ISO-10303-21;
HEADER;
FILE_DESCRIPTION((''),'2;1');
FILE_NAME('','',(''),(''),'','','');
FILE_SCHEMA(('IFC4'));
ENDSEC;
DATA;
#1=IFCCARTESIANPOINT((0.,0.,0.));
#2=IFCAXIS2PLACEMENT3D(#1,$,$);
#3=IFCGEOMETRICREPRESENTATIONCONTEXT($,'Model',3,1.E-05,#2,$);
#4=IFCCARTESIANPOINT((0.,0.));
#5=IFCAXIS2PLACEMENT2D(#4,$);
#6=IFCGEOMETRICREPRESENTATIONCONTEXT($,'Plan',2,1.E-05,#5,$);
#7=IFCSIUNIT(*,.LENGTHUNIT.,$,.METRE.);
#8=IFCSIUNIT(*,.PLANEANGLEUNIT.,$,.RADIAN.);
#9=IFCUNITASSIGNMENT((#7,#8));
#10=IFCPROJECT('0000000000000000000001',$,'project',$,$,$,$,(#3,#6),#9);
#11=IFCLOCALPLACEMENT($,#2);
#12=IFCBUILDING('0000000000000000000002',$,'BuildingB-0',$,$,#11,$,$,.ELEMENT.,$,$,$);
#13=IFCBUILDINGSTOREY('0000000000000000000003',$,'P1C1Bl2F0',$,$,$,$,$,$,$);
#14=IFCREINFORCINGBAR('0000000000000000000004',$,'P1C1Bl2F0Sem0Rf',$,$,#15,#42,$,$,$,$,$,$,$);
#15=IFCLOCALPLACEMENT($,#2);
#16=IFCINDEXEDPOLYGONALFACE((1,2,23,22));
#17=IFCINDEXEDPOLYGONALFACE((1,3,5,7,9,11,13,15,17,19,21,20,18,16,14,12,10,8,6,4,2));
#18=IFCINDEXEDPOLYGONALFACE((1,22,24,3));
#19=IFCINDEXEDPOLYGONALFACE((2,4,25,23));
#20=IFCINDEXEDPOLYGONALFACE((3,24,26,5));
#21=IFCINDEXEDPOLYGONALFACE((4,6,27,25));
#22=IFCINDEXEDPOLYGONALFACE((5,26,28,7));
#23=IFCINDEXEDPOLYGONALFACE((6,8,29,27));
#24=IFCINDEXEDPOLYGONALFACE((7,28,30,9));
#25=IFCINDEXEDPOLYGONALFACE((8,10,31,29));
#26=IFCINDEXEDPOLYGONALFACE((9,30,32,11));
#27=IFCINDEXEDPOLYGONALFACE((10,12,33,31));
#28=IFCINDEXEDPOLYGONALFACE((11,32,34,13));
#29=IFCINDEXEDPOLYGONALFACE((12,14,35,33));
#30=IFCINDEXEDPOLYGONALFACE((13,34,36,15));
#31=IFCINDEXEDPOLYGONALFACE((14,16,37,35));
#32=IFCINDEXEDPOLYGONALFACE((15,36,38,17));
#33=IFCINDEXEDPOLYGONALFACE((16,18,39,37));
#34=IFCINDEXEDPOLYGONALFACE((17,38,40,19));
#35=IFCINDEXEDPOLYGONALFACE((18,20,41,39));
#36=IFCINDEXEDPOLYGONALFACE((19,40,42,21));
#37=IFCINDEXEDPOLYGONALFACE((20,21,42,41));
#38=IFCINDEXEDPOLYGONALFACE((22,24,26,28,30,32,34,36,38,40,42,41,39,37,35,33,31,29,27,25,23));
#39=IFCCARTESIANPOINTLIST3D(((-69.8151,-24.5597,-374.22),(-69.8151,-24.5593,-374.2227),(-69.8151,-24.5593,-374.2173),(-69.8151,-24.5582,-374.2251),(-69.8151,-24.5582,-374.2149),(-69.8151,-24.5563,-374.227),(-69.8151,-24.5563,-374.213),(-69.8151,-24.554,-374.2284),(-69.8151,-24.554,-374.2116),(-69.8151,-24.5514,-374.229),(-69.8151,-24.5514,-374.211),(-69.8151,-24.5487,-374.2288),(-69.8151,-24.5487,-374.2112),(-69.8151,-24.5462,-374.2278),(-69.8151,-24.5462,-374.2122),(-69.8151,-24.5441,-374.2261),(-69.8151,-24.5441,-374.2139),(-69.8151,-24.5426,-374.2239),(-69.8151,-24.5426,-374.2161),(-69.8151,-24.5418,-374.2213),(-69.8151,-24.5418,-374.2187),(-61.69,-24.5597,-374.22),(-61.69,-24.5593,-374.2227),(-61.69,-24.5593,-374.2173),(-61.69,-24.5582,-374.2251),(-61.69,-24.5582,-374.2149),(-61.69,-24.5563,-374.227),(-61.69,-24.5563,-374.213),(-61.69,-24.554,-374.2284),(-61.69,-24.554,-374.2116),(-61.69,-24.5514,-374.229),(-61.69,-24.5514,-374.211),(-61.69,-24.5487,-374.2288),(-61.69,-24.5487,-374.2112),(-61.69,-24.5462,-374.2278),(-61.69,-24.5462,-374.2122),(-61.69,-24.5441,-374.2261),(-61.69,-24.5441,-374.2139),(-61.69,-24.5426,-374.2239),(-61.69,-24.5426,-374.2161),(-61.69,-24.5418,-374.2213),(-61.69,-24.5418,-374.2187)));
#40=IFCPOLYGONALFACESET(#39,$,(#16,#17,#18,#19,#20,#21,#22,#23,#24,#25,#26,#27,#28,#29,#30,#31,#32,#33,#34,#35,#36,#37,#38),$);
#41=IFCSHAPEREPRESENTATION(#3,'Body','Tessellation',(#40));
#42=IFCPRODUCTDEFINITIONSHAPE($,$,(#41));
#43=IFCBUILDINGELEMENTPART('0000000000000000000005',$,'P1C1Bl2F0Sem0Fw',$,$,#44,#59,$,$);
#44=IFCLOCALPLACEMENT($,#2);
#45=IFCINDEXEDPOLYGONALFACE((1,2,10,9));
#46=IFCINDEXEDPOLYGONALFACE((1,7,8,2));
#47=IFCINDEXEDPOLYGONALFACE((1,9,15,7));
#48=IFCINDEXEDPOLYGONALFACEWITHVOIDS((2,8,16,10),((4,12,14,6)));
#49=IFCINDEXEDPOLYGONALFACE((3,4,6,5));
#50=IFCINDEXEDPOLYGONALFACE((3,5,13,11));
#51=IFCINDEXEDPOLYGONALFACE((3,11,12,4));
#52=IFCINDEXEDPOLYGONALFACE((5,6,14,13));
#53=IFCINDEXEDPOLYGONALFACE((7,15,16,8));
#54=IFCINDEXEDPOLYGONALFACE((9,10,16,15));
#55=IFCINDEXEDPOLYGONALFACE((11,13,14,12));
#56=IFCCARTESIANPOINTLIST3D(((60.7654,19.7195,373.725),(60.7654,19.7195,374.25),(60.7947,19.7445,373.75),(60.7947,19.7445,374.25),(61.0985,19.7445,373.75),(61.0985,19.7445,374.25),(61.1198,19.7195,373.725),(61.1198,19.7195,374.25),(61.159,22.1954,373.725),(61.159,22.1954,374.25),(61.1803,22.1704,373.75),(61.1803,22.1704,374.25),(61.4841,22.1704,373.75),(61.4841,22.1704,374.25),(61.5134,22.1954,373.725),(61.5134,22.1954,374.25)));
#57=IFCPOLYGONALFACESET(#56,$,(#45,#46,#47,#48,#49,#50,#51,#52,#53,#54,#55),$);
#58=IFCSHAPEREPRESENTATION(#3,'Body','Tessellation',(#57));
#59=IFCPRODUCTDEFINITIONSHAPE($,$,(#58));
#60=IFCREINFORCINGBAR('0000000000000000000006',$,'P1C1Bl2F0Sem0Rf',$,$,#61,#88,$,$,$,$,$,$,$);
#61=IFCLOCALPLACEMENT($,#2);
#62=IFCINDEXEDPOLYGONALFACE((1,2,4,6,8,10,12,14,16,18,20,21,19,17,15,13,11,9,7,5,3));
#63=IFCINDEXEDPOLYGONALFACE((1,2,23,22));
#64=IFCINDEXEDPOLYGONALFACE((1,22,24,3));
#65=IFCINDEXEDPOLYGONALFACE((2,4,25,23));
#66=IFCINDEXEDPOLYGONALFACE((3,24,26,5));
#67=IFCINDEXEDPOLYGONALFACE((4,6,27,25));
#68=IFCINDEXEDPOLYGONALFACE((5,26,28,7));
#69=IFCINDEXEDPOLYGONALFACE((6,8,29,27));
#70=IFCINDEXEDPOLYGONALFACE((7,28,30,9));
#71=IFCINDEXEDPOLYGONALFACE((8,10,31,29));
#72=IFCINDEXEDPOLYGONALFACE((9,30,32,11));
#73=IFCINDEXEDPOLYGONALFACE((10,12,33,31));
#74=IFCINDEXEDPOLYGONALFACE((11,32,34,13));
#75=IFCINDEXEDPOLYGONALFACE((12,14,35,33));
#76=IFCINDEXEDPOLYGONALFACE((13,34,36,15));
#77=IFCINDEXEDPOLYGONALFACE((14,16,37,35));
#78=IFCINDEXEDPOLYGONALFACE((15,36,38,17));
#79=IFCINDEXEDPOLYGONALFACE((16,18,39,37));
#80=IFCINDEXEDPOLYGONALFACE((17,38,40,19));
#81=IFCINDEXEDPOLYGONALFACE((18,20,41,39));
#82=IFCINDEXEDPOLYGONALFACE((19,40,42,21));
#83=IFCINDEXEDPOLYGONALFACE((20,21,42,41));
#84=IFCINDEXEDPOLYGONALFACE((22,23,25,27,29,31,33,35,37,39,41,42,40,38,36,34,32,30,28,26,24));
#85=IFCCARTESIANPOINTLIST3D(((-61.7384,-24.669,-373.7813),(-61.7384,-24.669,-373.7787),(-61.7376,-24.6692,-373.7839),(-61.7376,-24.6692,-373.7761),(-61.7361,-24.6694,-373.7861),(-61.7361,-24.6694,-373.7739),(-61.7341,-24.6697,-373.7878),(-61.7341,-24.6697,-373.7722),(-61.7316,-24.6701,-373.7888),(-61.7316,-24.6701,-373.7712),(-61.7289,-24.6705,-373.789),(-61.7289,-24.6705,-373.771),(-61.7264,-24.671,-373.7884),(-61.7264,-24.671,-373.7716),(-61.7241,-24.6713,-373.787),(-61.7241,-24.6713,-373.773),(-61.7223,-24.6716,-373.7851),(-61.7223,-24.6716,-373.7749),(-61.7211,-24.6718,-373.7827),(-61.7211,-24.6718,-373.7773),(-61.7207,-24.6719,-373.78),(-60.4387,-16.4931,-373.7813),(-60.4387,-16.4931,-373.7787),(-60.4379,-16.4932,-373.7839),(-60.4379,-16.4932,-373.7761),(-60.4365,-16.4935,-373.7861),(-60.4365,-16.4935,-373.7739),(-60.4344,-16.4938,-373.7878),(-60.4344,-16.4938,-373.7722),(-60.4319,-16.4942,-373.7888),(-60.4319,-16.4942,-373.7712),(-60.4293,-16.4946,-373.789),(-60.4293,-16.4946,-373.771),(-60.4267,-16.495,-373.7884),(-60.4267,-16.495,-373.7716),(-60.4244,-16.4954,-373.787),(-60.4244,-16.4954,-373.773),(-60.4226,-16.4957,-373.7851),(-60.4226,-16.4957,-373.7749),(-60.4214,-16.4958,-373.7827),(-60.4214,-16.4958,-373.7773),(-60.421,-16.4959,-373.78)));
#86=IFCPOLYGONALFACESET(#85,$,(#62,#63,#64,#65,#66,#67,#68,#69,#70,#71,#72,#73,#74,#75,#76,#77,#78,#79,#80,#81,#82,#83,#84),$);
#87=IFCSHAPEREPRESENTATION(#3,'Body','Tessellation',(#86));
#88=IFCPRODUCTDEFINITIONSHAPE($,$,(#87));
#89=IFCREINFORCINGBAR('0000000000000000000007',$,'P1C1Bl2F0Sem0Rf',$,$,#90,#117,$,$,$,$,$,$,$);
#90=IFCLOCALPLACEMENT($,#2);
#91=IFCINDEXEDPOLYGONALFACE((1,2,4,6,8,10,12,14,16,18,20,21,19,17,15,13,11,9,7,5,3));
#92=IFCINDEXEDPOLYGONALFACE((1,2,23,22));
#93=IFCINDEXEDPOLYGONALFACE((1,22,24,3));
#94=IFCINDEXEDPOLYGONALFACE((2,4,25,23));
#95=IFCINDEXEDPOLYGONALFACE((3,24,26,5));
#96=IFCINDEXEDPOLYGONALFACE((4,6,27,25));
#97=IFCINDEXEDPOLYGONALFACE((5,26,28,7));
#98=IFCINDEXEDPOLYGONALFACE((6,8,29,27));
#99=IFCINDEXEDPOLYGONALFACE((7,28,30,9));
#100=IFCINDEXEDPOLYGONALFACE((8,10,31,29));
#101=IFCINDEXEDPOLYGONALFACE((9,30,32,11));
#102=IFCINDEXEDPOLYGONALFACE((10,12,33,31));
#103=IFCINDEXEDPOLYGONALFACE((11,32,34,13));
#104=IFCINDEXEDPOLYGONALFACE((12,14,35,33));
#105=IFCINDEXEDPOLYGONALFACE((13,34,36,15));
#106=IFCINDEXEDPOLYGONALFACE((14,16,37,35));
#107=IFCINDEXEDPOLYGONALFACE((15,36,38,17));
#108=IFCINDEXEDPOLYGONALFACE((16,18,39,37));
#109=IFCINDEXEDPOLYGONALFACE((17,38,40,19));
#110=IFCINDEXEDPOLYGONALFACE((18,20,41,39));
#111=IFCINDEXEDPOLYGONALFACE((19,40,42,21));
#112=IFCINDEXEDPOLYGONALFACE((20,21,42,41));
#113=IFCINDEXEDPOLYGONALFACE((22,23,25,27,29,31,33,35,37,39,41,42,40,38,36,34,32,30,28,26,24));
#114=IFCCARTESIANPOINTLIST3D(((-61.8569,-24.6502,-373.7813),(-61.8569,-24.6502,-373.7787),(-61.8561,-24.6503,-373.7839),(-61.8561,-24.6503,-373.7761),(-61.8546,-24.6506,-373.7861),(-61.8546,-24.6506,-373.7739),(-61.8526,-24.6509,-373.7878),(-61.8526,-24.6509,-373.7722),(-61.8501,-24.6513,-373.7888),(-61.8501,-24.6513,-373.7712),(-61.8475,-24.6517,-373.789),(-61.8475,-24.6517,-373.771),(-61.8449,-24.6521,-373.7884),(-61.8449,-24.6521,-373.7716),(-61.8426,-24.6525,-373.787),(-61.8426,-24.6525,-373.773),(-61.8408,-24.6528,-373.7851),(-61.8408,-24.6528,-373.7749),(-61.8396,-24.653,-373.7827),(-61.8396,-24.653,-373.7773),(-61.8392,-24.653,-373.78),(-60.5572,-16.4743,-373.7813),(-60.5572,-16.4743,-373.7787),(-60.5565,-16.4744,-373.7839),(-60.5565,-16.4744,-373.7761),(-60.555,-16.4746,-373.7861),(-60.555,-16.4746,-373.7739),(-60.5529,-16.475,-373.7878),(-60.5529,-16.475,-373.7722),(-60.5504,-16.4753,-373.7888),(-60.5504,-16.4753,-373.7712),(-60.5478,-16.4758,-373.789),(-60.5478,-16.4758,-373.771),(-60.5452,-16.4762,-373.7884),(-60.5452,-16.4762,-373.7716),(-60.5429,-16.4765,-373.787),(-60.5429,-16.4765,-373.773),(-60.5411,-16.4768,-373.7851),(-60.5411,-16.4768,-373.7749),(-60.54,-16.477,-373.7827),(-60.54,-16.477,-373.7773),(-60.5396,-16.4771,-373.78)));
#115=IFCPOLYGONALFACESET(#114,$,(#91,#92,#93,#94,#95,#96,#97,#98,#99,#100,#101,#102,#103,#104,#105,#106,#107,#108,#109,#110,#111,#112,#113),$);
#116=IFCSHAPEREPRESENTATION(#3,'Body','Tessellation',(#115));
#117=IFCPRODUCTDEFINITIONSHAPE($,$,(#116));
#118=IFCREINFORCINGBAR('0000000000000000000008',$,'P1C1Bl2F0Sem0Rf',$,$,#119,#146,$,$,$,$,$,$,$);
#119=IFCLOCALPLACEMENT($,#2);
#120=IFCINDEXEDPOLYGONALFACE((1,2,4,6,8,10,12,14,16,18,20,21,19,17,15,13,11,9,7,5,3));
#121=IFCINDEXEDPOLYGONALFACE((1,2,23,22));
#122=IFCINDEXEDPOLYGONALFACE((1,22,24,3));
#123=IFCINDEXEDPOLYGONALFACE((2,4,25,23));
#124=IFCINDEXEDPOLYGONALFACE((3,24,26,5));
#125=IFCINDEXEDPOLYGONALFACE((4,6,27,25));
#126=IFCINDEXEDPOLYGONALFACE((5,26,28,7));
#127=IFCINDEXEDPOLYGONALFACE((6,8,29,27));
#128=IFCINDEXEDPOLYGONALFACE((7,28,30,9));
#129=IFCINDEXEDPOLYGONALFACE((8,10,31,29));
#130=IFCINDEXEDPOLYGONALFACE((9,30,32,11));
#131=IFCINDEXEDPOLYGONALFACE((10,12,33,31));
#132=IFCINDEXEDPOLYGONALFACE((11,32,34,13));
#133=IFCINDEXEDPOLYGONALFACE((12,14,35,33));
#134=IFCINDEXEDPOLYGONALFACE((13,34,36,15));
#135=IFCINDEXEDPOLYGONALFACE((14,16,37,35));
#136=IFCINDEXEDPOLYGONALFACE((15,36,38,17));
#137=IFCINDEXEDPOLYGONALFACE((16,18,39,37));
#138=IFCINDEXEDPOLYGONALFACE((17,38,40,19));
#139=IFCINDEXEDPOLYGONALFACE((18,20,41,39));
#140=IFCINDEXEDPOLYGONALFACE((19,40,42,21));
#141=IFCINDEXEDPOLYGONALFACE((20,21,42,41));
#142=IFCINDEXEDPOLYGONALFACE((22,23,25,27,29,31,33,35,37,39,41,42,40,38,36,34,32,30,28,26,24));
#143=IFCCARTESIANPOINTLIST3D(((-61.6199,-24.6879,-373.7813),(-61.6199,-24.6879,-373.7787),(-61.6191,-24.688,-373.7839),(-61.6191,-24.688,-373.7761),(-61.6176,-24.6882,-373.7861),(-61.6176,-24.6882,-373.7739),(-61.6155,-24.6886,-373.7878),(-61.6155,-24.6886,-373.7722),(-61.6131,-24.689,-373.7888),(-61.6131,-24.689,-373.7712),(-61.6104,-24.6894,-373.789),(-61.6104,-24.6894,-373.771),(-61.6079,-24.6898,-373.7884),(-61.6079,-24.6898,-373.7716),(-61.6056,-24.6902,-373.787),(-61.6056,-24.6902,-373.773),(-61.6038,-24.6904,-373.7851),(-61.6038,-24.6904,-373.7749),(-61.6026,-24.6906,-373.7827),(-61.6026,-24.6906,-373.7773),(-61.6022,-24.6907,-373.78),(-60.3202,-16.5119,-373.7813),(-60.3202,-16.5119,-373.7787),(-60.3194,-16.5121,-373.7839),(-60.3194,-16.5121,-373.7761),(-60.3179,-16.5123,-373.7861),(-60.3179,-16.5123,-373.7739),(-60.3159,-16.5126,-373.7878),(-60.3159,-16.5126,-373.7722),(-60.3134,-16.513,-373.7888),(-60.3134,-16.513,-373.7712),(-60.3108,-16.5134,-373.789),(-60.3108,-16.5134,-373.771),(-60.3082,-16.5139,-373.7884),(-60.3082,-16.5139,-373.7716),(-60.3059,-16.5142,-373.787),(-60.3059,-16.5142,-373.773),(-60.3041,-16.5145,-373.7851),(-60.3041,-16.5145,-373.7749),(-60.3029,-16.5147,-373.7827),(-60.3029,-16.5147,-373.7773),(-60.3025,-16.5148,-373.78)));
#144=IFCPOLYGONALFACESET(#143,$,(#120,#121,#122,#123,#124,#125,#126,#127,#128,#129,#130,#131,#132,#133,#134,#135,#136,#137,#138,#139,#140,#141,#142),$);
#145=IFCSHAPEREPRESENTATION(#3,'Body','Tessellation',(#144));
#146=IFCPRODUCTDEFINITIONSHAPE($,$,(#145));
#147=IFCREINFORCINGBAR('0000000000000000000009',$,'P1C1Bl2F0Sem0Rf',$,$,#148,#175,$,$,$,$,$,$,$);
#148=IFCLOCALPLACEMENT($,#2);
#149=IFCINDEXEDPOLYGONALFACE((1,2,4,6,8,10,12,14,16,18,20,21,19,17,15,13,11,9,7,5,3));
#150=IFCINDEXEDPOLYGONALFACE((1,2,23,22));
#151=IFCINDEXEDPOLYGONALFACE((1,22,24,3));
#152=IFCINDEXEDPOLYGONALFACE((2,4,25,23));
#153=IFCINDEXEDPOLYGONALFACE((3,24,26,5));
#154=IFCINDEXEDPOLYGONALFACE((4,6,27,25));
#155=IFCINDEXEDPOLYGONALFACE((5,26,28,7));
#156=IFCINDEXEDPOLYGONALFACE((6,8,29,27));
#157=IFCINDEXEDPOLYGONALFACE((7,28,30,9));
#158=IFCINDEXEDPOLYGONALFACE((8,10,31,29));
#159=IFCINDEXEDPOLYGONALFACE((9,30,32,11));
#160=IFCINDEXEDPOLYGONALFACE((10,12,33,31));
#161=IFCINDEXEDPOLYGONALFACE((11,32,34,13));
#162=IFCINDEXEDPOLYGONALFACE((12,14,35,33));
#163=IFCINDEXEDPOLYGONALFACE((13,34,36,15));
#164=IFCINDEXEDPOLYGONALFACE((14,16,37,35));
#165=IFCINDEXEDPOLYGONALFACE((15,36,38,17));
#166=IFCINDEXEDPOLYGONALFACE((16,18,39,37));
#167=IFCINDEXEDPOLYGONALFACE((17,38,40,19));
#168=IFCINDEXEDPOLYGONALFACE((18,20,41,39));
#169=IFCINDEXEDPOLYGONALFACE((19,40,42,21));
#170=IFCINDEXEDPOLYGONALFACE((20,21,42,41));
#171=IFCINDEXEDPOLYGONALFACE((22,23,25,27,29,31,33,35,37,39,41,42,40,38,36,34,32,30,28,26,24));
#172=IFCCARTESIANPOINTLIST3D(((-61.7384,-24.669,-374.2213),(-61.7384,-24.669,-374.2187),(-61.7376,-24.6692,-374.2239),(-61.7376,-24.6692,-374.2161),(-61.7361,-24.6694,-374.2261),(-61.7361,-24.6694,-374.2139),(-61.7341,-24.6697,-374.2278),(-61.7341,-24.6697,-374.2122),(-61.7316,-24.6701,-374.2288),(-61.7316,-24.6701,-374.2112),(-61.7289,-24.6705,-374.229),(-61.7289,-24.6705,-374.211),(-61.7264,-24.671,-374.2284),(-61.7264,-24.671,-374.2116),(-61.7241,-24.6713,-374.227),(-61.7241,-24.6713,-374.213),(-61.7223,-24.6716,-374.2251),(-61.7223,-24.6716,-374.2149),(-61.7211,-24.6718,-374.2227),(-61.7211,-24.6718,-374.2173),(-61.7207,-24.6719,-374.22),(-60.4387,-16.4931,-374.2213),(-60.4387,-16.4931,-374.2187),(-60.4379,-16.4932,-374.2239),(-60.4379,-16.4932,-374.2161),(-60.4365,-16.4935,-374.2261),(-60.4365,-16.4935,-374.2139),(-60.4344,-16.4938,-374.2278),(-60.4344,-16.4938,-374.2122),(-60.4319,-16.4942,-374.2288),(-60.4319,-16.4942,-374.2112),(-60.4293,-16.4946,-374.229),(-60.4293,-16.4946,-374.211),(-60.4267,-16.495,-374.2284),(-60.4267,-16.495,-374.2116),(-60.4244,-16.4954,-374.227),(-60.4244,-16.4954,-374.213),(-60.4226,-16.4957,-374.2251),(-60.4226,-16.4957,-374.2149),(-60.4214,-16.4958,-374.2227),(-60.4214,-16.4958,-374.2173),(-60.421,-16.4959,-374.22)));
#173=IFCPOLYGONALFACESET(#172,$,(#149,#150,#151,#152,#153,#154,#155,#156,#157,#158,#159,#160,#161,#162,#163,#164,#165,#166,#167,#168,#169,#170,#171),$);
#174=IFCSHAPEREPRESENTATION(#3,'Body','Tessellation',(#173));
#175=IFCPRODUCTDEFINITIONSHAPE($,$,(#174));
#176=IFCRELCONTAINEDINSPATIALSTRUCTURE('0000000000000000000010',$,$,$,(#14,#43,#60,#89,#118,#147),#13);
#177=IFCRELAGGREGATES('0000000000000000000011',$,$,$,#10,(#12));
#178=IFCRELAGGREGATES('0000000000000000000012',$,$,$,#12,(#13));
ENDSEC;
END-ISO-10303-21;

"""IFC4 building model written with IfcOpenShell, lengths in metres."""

from ifc_helpers import new_model, entity, si_unit, origin, origin_2d, place, context, project, spatial, polyline, outline, extrude, element, save


model = new_model("IFC4")

# Units and contexts
model_context = context("Model", 3, precision=1e-05, world=origin())
plan_context = context("Plan", 2, precision=1e-05, world=origin_2d())
ifc_project = project(units=[si_unit("LENGTHUNIT", "METRE"), si_unit("PLANEANGLEUNIT", "RADIAN")], contexts=[model_context, plan_context])

# Building, storey
building_placement = place(None, origin())
building = spatial("IfcBuilding", under=ifc_project, at=building_placement, Name="BuildingB-0", CompositionType="ELEMENT")
storey = spatial("IfcBuildingStorey", under=building, Name="P1C1Bl2F0")

# Reinforcing bar
element("IfcReinforcingBar", 1, inside=storey, Name="P1C1Bl2F0Sem0Rf", context=model_context, shape_type="SweptSolid", body=[
    entity("IfcSurfaceCurveSweptAreaSolid", entity("IfcCircleProfileDef", "AREA", None, None, 0.009), None, entity("IfcPolyline", [entity("IfcCartesianPoint", [69.8151, 24.5507, 374.22]), entity("IfcCartesianPoint", [61.69, 24.5507, 374.22])]), None, None, entity("IfcPlane", entity("IfcAxis2Placement3D", entity("IfcCartesianPoint", [69.8151, 24.5507, 374.22]), entity("IfcDirection", [0.0, 0.0, 1.0]), entity("IfcDirection", [1.0, 0.0, 0.0])))),
])

# Building element part, opening
building_element_part_1 = element("IfcBuildingElementPart", 2, inside=storey, Name="P1C1Bl2F0Sem0Fw", context=model_context, shape_type="SweptSolid", body=[
    extrude(outline(polyline([(61.1198, 19.7195, 373.725), (60.7654, 19.7195, 373.725), (61.159, 22.1954, 373.725), (61.5134, 22.1954, 373.725), (61.1198, 19.7195, 373.725)])), None, (0.0, 0.0, 1.0), 0.525),
])
element("IfcOpeningElement", 3, inside=storey, cuts=building_element_part_1, context=model_context, shape_type="SweptSolid", body=[
    extrude(outline(polyline([(61.0985, 19.7445, 373.75), (60.7947, 19.7445, 373.75), (61.1803, 22.1704, 373.75), (61.4841, 22.1704, 373.75), (61.0985, 19.7445, 373.75)])), None, (0.0, 0.0, 1.0), 0.5),
])

# Reinforcing bars
element("IfcReinforcingBar", 4, inside=storey, Name="P1C1Bl2F0Sem0Rf", context=model_context, shape_type="SweptSolid", body=[
    entity("IfcSurfaceCurveSweptAreaSolid", entity("IfcCircleProfileDef", "AREA", None, None, 0.009), None, entity("IfcPolyline", [entity("IfcCartesianPoint", [60.4299, 16.4945, 373.78]), entity("IfcCartesianPoint", [61.7296, 24.6704, 373.78])]), None, None, entity("IfcPlane", entity("IfcAxis2Placement3D", entity("IfcCartesianPoint", [60.4299, 16.4945, 373.78]), entity("IfcDirection", [0.0, 0.0, 1.0]), entity("IfcDirection", [1.0, 0.0, 0.0])))),
])
element("IfcReinforcingBar", 5, inside=storey, Name="P1C1Bl2F0Sem0Rf", context=model_context, shape_type="SweptSolid", body=[
    entity("IfcSurfaceCurveSweptAreaSolid", entity("IfcCircleProfileDef", "AREA", None, None, 0.009), None, entity("IfcPolyline", [entity("IfcCartesianPoint", [60.5484, 16.4757, 373.78]), entity("IfcCartesianPoint", [61.8481, 24.6516, 373.78])]), None, None, entity("IfcPlane", entity("IfcAxis2Placement3D", entity("IfcCartesianPoint", [60.5484, 16.4757, 373.78]), entity("IfcDirection", [0.0, 0.0, 1.0]), entity("IfcDirection", [1.0, 0.0, 0.0])))),
])
element("IfcReinforcingBar", 6, inside=storey, Name="P1C1Bl2F0Sem0Rf", context=model_context, shape_type="SweptSolid", body=[
    entity("IfcSurfaceCurveSweptAreaSolid", entity("IfcCircleProfileDef", "AREA", None, None, 0.009), None, entity("IfcPolyline", [entity("IfcCartesianPoint", [60.3114, 16.5133, 373.78]), entity("IfcCartesianPoint", [61.6111, 24.6893, 373.78])]), None, None, entity("IfcPlane", entity("IfcAxis2Placement3D", entity("IfcCartesianPoint", [60.3114, 16.5133, 373.78]), entity("IfcDirection", [0.0, 0.0, 1.0]), entity("IfcDirection", [1.0, 0.0, 0.0])))),
])
element("IfcReinforcingBar", 7, inside=storey, Name="P1C1Bl2F0Sem0Rf", context=model_context, shape_type="SweptSolid", body=[
    entity("IfcSurfaceCurveSweptAreaSolid", entity("IfcCircleProfileDef", "AREA", None, None, 0.009), None, entity("IfcPolyline", [entity("IfcCartesianPoint", [60.4299, 16.4945, 374.22]), entity("IfcCartesianPoint", [61.7296, 24.6704, 374.22])]), None, None, entity("IfcPlane", entity("IfcAxis2Placement3D", entity("IfcCartesianPoint", [60.4299, 16.4945, 374.22]), entity("IfcDirection", [0.0, 0.0, 1.0]), entity("IfcDirection", [1.0, 0.0, 0.0])))),
])

save(model, "model.ifc")
